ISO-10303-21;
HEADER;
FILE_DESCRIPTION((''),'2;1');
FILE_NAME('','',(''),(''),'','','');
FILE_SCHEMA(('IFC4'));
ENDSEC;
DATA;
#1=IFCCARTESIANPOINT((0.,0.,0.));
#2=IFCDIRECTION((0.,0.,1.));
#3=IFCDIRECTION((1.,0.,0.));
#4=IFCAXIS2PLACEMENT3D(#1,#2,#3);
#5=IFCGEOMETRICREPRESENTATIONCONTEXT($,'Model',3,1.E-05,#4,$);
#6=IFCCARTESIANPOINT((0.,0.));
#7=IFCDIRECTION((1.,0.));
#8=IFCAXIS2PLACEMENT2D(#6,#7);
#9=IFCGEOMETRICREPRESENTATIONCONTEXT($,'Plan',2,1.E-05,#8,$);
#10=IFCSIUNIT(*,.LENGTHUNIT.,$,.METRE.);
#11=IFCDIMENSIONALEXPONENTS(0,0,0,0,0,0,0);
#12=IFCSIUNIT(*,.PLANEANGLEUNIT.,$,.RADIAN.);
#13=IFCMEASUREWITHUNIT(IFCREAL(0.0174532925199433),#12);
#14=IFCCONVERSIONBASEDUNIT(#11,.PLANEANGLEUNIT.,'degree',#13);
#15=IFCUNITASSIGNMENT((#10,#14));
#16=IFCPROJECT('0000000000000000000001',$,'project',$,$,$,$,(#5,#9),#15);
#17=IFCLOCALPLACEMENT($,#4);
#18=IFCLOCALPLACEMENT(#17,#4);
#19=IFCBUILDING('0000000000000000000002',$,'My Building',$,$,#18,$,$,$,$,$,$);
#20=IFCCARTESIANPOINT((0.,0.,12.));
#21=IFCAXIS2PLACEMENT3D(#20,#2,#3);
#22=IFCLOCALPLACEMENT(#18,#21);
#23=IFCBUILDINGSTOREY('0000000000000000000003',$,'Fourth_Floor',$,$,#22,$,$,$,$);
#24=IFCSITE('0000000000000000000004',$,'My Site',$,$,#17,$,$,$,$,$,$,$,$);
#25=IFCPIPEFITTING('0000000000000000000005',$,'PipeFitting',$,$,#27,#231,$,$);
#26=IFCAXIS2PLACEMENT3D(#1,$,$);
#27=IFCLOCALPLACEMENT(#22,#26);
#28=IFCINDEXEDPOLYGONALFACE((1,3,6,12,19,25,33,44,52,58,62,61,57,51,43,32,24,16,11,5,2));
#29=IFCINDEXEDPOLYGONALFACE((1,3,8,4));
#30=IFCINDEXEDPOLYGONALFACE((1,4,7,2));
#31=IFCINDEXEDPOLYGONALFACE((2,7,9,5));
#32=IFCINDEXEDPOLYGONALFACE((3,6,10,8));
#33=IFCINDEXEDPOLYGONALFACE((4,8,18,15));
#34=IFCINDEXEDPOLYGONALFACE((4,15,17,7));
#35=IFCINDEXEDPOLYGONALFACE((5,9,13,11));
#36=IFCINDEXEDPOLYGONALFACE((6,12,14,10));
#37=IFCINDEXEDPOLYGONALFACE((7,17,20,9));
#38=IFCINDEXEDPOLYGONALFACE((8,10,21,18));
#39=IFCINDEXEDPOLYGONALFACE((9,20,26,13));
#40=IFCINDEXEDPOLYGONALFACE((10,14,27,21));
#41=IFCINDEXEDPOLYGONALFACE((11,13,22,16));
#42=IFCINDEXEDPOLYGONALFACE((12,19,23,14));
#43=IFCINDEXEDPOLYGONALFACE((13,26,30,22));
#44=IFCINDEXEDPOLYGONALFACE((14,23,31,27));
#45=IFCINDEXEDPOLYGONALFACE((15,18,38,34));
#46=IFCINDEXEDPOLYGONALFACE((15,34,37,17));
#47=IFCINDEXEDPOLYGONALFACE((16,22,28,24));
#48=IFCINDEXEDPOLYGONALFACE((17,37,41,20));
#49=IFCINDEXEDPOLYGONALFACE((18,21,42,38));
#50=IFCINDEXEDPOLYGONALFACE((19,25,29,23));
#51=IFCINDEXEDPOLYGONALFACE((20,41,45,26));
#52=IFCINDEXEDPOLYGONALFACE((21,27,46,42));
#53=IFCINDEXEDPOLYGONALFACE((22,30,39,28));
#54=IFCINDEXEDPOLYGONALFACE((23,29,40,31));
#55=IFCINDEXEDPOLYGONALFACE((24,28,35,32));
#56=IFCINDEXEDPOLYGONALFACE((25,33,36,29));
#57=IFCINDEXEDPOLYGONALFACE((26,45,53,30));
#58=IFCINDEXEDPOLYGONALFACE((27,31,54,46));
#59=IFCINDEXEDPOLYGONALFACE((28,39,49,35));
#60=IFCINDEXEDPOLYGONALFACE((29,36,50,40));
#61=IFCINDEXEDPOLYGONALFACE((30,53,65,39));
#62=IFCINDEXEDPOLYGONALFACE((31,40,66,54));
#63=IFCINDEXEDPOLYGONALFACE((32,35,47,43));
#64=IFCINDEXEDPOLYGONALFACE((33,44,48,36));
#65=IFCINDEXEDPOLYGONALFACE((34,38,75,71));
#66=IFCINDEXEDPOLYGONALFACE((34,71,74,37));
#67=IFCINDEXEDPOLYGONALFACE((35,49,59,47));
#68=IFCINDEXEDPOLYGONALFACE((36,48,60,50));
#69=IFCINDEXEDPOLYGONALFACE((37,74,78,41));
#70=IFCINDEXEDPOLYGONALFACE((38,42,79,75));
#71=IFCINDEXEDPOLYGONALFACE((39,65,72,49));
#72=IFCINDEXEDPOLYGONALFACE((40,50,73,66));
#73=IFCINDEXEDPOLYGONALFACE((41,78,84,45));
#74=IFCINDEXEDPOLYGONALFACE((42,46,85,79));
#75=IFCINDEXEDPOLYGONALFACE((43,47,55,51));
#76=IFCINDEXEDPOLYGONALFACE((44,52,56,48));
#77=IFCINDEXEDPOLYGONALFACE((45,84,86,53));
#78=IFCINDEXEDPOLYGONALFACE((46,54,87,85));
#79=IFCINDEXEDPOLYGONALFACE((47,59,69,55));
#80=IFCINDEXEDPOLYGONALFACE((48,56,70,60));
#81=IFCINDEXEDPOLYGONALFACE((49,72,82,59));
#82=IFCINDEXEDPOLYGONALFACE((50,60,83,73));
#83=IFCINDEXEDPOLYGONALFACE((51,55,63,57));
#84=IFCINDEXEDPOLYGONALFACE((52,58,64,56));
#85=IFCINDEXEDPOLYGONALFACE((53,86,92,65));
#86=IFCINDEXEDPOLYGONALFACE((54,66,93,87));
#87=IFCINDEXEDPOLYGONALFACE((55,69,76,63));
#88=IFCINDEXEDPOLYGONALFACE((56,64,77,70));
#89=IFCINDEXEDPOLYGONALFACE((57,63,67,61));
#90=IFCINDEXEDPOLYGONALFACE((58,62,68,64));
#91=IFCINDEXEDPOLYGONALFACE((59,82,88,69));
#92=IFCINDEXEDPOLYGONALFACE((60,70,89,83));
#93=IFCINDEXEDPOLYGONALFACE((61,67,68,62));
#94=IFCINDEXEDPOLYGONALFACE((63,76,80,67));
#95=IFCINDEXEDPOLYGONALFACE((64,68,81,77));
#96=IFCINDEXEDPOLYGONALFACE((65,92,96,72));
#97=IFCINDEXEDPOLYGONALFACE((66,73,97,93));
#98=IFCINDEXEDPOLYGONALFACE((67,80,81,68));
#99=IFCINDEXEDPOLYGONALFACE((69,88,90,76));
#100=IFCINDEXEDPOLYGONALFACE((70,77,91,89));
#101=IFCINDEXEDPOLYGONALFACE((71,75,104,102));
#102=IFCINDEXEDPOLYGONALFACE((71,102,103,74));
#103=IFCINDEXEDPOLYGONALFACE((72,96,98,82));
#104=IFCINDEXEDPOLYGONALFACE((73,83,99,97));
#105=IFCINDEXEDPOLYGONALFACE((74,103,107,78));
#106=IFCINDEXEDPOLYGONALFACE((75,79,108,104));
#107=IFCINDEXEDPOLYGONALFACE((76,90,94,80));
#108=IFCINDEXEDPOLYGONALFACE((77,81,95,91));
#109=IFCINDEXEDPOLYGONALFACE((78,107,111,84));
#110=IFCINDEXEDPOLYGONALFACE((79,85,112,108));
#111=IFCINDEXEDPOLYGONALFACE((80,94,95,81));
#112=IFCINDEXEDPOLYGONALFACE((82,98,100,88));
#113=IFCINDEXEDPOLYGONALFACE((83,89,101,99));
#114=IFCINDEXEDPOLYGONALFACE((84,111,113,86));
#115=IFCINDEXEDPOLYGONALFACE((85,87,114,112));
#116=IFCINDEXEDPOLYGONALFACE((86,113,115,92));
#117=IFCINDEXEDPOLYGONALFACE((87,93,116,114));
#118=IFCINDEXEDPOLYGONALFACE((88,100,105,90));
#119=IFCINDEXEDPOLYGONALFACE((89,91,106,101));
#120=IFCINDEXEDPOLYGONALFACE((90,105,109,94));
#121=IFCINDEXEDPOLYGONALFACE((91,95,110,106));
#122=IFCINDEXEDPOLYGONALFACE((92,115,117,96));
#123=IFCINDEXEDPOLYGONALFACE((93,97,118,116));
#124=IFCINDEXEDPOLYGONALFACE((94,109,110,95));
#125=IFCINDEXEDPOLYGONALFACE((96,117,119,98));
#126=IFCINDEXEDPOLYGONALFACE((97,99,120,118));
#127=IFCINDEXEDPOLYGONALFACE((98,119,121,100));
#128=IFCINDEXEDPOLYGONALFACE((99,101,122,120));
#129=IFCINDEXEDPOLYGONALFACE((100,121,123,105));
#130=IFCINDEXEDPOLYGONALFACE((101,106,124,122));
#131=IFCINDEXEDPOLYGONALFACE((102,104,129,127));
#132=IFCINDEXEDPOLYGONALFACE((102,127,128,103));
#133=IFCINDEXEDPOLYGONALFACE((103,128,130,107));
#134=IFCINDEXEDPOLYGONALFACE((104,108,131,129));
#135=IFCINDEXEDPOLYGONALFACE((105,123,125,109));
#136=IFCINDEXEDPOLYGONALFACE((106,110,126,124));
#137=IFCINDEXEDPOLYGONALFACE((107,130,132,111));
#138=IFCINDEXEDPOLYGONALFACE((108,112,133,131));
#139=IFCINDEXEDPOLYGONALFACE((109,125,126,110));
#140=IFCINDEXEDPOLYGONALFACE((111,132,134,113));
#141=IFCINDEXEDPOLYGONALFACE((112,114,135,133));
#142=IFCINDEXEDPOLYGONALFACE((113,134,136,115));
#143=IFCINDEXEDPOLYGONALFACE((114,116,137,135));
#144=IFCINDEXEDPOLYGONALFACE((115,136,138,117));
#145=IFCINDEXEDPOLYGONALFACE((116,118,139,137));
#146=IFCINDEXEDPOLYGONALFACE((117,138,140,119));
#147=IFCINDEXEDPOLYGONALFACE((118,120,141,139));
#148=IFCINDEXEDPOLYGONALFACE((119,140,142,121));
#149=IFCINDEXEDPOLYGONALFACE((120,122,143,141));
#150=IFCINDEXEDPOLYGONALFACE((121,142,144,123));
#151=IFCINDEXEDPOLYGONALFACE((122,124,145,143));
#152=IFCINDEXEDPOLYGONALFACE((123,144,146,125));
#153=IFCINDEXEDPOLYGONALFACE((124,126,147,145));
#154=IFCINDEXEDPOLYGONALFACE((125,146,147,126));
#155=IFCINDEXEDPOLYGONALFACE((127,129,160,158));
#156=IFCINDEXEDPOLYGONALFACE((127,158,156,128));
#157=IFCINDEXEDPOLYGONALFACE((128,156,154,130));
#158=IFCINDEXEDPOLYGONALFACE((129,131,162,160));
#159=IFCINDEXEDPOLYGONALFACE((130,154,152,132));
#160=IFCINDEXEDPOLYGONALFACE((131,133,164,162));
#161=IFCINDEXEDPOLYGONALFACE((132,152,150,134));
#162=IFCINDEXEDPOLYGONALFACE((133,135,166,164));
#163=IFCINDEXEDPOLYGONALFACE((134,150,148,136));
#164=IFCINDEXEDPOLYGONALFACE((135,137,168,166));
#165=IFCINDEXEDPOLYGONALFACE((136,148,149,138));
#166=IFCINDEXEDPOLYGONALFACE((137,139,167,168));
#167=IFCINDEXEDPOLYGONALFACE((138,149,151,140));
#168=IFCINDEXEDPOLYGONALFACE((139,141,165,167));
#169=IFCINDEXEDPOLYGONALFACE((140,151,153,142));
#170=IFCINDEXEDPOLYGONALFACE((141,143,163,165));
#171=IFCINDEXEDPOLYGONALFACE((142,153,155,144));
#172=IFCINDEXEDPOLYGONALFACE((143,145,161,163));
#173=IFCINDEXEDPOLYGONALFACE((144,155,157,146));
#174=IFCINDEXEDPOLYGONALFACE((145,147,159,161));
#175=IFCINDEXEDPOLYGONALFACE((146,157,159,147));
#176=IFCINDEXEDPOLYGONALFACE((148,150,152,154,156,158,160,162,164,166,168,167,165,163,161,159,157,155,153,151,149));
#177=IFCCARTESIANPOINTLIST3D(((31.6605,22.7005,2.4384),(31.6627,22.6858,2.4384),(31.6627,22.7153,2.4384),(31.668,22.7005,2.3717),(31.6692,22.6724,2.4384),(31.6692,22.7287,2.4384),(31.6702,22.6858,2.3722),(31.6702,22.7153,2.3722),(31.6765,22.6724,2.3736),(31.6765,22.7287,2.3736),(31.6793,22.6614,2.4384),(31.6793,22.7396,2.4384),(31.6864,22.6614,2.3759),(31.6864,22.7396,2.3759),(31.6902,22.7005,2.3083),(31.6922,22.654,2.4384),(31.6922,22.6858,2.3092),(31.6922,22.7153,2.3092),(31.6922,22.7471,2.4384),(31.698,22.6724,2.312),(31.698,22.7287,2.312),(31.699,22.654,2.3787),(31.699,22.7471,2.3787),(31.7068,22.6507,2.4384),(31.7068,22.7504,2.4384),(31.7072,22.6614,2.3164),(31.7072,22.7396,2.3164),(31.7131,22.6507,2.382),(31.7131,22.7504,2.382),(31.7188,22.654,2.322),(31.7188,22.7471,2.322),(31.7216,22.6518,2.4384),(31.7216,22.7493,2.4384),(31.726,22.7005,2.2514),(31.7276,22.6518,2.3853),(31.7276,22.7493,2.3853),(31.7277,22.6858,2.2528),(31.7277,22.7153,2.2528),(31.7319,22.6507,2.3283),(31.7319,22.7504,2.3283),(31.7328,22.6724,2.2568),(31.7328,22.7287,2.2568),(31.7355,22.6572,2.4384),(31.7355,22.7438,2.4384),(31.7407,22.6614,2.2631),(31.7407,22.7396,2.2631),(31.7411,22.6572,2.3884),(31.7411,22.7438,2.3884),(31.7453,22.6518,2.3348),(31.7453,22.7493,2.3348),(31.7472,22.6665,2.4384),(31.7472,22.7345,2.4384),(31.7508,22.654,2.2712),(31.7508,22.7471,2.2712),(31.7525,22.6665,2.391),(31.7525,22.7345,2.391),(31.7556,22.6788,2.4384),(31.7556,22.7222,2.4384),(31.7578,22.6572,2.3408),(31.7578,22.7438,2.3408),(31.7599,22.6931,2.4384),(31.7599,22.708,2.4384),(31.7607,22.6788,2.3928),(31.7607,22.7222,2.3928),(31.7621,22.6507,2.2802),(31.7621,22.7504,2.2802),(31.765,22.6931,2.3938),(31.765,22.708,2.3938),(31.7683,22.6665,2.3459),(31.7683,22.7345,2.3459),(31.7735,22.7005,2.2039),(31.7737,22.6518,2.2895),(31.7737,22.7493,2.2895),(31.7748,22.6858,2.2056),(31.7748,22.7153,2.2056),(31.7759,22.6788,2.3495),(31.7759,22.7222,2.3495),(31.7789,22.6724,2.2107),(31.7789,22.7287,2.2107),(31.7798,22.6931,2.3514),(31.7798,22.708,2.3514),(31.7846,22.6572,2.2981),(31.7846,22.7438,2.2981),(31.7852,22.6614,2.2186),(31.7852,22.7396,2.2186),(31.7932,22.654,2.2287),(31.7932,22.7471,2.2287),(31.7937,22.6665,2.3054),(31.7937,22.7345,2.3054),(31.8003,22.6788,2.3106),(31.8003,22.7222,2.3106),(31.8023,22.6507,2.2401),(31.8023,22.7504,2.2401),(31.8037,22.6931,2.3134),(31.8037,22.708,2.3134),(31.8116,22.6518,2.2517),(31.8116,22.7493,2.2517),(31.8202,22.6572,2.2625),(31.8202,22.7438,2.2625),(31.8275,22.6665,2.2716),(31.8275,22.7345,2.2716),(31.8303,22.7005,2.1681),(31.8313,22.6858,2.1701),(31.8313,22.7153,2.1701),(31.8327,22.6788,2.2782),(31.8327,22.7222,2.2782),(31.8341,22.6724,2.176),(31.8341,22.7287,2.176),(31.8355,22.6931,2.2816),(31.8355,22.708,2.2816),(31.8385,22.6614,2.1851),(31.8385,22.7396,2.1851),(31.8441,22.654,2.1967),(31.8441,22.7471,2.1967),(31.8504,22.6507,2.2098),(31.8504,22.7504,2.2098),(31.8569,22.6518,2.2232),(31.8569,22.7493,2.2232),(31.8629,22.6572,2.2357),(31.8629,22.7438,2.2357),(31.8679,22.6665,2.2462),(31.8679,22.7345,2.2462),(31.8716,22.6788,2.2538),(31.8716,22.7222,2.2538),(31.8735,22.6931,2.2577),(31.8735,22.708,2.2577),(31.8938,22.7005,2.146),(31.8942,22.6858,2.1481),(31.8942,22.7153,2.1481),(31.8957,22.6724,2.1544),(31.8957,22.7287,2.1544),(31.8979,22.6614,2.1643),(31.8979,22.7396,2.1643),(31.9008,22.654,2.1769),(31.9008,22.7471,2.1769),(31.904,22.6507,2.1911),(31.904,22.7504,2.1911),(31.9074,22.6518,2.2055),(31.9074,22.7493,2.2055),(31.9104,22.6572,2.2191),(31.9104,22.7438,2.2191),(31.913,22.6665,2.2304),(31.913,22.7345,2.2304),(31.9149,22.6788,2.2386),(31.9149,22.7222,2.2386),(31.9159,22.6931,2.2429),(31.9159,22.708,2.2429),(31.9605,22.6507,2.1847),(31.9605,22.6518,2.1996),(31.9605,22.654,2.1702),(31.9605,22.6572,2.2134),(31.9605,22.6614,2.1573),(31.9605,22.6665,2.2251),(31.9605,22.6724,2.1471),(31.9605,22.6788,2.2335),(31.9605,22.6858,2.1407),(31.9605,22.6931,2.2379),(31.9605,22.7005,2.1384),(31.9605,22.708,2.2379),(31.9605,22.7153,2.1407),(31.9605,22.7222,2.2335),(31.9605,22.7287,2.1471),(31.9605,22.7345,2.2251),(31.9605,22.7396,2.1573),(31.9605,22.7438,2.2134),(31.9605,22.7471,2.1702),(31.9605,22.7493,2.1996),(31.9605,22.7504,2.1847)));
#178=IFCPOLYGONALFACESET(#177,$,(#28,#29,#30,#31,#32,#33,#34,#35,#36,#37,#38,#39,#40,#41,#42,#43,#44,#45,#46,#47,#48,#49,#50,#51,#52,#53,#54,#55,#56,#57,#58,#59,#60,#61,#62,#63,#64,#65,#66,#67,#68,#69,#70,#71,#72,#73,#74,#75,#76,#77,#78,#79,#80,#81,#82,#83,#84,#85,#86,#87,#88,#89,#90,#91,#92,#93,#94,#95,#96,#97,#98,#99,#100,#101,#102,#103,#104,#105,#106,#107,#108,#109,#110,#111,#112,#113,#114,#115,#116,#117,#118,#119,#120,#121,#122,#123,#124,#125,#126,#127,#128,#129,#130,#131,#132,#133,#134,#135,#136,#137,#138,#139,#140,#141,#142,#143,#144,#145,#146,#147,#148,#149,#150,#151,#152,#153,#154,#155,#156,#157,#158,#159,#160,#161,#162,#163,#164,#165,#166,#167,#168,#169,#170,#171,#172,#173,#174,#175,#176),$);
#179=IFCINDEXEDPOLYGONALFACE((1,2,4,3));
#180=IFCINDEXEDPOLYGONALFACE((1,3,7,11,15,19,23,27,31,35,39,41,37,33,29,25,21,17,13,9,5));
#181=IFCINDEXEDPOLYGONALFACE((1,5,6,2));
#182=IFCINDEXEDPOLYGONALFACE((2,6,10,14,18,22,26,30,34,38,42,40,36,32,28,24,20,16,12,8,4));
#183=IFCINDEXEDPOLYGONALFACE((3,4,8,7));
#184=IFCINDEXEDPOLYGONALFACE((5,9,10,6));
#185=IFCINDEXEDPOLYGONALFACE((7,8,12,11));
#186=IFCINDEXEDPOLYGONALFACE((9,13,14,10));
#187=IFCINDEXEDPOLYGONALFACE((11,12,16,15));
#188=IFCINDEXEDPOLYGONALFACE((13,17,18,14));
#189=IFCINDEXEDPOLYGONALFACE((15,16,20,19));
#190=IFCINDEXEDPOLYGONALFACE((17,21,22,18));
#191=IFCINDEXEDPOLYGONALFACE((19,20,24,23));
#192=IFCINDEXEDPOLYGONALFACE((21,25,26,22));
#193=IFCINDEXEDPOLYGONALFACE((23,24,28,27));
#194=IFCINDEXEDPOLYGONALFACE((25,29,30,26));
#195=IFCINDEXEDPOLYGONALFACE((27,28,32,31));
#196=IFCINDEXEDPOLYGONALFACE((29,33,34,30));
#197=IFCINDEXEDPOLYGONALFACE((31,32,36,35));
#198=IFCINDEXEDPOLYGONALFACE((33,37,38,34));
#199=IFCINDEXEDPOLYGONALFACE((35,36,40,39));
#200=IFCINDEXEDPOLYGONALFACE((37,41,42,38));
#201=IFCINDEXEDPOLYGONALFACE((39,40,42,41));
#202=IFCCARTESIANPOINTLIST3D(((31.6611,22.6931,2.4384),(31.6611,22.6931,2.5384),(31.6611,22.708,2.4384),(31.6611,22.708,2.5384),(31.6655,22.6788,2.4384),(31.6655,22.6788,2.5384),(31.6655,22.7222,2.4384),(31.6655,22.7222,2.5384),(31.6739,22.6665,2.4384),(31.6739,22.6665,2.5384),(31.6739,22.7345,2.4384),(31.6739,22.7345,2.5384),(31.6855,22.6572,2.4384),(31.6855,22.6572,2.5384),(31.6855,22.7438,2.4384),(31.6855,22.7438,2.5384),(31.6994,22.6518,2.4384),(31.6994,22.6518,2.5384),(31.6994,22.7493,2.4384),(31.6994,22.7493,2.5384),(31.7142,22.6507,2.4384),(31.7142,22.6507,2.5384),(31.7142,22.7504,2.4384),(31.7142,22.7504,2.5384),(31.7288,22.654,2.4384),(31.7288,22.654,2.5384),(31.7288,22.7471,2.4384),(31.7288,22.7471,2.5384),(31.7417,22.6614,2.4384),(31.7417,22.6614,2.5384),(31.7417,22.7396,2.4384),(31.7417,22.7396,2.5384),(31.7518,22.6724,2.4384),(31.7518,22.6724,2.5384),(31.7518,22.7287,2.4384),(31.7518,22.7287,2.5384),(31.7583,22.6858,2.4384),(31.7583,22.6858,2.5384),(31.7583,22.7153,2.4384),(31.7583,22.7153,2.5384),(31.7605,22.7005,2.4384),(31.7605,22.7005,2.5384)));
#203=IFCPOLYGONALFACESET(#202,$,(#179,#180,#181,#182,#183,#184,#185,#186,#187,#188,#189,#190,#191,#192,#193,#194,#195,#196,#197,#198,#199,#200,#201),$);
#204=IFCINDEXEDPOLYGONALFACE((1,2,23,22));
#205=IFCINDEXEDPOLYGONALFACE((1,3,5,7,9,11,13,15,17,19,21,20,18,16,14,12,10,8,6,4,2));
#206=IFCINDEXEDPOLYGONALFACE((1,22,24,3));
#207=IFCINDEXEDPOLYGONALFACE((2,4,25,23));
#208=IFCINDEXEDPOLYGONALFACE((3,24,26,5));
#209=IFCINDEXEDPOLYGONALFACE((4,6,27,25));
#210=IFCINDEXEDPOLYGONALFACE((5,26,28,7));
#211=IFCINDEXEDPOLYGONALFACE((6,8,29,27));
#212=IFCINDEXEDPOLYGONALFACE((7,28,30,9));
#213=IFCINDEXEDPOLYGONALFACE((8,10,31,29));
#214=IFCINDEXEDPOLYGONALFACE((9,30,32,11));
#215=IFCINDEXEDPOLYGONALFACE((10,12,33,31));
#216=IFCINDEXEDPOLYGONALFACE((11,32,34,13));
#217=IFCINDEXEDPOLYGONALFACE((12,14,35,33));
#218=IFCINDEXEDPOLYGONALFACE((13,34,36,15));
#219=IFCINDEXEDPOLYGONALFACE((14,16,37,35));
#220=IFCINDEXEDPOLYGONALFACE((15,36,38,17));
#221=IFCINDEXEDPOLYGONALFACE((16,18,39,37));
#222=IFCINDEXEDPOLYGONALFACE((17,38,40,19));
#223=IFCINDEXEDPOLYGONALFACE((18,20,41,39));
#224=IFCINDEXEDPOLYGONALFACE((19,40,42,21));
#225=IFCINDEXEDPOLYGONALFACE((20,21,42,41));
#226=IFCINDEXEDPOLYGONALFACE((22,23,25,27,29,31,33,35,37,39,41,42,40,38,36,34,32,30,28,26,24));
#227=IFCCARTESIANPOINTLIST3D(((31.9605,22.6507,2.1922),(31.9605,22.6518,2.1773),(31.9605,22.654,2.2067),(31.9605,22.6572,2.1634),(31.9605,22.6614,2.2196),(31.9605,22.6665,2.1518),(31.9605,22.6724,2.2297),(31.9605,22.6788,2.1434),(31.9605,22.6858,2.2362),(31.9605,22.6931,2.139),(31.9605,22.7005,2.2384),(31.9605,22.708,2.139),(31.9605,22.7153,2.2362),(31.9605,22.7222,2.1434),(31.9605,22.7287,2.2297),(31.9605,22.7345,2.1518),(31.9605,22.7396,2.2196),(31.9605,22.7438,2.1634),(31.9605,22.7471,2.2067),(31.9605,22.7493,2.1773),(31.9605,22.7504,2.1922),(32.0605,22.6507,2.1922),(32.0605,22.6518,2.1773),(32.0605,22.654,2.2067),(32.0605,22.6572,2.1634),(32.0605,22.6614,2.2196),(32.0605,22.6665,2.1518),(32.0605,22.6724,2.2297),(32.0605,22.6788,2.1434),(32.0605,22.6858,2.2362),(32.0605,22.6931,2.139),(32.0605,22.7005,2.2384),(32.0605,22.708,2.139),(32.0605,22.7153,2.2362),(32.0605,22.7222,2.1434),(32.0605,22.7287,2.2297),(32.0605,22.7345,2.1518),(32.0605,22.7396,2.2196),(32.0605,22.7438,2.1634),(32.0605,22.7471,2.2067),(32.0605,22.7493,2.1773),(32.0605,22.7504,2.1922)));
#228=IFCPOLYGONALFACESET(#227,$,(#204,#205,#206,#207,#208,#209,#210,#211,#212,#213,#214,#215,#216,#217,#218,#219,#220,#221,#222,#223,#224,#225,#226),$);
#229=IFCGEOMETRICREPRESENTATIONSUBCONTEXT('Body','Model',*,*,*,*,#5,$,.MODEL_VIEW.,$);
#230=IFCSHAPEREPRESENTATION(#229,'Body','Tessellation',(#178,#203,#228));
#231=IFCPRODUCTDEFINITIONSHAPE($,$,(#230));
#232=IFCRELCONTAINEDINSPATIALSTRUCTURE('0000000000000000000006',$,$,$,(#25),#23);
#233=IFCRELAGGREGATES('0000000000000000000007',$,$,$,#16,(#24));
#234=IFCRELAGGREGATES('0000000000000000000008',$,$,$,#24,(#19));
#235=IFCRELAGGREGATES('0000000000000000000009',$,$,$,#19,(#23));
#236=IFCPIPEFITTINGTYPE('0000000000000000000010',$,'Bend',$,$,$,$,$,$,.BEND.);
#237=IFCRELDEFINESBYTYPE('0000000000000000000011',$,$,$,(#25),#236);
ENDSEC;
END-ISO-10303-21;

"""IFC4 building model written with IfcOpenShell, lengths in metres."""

from ifc_helpers import new_model, entity, si_unit, converted_unit, frame, origin_with_axes, origin_2d_with_axis, place, context, subcontext, project, spatial, circle, extrude, source, transform, mapped, type_object, type_shapes, element, save


model = new_model("IFC4")

# Units and contexts
model_context = context("Model", 3, precision=1e-05, world=origin_with_axes())
plan_context = context("Plan", 2, precision=1e-05, world=origin_2d_with_axis())
body_context_1 = subcontext(model_context, "Body", "Model", "MODEL_VIEW")
ifc_project = project(units=[si_unit("LENGTHUNIT", "METRE"), converted_unit("PLANEANGLEUNIT", "degree", entity("IfcReal", 0.0174532925199433), si_unit("PLANEANGLEUNIT", "RADIAN"), dimensions=[0, 0, 0, 0, 0, 0, 0])], contexts=[model_context, plan_context])

# Site, building, storey
site_placement = place(None, origin_with_axes())
site = spatial("IfcSite", under=ifc_project, at=site_placement, Name="My Site")
building_placement = place(site_placement, origin_with_axes())
building = spatial("IfcBuilding", under=site, at=building_placement, Name="My Building")
storey_placement = place(building_placement, frame((0.0, 0.0, 12.0), z_axis=(0.0, 0.0, 1.0), x_axis=(1.0, 0.0, 0.0)))
storey = spatial("IfcBuildingStorey", under=building, at=storey_placement, Name="Fourth_Floor")

# Pipe fitting
pipe_fitting_type = type_object("IfcPipeFittingType", Name="Bend", PredefinedType="BEND")
shared_shape_1 = source(origin_with_axes(), body_context_1, "Body", "SolidModel", [
    entity("IfcSweptDiskSolid", entity("IfcIndexedPolyCurve", entity("IfcCartesianPointList3D", [[0.0, 0.0, -0.1], [0.0732, 0.0, -0.2768], [0.25, 0.0, -0.35]]), [entity("IfcArcIndex", [1, 2, 3])]), 0.05),
    extrude(circle(Radius=0.05), origin_with_axes(), (0.0, 0.0, -1.0), 0.1),
    extrude(circle(Radius=0.05), frame((0.25, 0.0, -0.35), z_axis=(1.0, 0.0, 0.0), x_axis=(0.0, 0.0, 1.0)), (0.0, 0.0, 1.0), 0.1),
])
type_shapes(pipe_fitting_type, [shared_shape_1])
pipe_fitting_placement = place(storey_placement, frame((31.7105, 22.7005, 2.5384), z_axis=(0.0, 0.0, 1.0), x_axis=(1.0, 0.0, 0.0)))
element("IfcPipeFitting", 1, at=pipe_fitting_placement, inside=storey, type_object=pipe_fitting_type, Name="PipeFitting", context=body_context_1, shape_type="MappedRepresentation", body=[
    mapped(shared_shape_1, transform((0.0, 0.0, 0.0), x_axis=(1.0, 0.0, 0.0), y_axis=(0.0, 1.0, 0.0), z_axis=(0.0, 0.0, 1.0), scale=1.0)),
])

save(model, "model.ifc")
